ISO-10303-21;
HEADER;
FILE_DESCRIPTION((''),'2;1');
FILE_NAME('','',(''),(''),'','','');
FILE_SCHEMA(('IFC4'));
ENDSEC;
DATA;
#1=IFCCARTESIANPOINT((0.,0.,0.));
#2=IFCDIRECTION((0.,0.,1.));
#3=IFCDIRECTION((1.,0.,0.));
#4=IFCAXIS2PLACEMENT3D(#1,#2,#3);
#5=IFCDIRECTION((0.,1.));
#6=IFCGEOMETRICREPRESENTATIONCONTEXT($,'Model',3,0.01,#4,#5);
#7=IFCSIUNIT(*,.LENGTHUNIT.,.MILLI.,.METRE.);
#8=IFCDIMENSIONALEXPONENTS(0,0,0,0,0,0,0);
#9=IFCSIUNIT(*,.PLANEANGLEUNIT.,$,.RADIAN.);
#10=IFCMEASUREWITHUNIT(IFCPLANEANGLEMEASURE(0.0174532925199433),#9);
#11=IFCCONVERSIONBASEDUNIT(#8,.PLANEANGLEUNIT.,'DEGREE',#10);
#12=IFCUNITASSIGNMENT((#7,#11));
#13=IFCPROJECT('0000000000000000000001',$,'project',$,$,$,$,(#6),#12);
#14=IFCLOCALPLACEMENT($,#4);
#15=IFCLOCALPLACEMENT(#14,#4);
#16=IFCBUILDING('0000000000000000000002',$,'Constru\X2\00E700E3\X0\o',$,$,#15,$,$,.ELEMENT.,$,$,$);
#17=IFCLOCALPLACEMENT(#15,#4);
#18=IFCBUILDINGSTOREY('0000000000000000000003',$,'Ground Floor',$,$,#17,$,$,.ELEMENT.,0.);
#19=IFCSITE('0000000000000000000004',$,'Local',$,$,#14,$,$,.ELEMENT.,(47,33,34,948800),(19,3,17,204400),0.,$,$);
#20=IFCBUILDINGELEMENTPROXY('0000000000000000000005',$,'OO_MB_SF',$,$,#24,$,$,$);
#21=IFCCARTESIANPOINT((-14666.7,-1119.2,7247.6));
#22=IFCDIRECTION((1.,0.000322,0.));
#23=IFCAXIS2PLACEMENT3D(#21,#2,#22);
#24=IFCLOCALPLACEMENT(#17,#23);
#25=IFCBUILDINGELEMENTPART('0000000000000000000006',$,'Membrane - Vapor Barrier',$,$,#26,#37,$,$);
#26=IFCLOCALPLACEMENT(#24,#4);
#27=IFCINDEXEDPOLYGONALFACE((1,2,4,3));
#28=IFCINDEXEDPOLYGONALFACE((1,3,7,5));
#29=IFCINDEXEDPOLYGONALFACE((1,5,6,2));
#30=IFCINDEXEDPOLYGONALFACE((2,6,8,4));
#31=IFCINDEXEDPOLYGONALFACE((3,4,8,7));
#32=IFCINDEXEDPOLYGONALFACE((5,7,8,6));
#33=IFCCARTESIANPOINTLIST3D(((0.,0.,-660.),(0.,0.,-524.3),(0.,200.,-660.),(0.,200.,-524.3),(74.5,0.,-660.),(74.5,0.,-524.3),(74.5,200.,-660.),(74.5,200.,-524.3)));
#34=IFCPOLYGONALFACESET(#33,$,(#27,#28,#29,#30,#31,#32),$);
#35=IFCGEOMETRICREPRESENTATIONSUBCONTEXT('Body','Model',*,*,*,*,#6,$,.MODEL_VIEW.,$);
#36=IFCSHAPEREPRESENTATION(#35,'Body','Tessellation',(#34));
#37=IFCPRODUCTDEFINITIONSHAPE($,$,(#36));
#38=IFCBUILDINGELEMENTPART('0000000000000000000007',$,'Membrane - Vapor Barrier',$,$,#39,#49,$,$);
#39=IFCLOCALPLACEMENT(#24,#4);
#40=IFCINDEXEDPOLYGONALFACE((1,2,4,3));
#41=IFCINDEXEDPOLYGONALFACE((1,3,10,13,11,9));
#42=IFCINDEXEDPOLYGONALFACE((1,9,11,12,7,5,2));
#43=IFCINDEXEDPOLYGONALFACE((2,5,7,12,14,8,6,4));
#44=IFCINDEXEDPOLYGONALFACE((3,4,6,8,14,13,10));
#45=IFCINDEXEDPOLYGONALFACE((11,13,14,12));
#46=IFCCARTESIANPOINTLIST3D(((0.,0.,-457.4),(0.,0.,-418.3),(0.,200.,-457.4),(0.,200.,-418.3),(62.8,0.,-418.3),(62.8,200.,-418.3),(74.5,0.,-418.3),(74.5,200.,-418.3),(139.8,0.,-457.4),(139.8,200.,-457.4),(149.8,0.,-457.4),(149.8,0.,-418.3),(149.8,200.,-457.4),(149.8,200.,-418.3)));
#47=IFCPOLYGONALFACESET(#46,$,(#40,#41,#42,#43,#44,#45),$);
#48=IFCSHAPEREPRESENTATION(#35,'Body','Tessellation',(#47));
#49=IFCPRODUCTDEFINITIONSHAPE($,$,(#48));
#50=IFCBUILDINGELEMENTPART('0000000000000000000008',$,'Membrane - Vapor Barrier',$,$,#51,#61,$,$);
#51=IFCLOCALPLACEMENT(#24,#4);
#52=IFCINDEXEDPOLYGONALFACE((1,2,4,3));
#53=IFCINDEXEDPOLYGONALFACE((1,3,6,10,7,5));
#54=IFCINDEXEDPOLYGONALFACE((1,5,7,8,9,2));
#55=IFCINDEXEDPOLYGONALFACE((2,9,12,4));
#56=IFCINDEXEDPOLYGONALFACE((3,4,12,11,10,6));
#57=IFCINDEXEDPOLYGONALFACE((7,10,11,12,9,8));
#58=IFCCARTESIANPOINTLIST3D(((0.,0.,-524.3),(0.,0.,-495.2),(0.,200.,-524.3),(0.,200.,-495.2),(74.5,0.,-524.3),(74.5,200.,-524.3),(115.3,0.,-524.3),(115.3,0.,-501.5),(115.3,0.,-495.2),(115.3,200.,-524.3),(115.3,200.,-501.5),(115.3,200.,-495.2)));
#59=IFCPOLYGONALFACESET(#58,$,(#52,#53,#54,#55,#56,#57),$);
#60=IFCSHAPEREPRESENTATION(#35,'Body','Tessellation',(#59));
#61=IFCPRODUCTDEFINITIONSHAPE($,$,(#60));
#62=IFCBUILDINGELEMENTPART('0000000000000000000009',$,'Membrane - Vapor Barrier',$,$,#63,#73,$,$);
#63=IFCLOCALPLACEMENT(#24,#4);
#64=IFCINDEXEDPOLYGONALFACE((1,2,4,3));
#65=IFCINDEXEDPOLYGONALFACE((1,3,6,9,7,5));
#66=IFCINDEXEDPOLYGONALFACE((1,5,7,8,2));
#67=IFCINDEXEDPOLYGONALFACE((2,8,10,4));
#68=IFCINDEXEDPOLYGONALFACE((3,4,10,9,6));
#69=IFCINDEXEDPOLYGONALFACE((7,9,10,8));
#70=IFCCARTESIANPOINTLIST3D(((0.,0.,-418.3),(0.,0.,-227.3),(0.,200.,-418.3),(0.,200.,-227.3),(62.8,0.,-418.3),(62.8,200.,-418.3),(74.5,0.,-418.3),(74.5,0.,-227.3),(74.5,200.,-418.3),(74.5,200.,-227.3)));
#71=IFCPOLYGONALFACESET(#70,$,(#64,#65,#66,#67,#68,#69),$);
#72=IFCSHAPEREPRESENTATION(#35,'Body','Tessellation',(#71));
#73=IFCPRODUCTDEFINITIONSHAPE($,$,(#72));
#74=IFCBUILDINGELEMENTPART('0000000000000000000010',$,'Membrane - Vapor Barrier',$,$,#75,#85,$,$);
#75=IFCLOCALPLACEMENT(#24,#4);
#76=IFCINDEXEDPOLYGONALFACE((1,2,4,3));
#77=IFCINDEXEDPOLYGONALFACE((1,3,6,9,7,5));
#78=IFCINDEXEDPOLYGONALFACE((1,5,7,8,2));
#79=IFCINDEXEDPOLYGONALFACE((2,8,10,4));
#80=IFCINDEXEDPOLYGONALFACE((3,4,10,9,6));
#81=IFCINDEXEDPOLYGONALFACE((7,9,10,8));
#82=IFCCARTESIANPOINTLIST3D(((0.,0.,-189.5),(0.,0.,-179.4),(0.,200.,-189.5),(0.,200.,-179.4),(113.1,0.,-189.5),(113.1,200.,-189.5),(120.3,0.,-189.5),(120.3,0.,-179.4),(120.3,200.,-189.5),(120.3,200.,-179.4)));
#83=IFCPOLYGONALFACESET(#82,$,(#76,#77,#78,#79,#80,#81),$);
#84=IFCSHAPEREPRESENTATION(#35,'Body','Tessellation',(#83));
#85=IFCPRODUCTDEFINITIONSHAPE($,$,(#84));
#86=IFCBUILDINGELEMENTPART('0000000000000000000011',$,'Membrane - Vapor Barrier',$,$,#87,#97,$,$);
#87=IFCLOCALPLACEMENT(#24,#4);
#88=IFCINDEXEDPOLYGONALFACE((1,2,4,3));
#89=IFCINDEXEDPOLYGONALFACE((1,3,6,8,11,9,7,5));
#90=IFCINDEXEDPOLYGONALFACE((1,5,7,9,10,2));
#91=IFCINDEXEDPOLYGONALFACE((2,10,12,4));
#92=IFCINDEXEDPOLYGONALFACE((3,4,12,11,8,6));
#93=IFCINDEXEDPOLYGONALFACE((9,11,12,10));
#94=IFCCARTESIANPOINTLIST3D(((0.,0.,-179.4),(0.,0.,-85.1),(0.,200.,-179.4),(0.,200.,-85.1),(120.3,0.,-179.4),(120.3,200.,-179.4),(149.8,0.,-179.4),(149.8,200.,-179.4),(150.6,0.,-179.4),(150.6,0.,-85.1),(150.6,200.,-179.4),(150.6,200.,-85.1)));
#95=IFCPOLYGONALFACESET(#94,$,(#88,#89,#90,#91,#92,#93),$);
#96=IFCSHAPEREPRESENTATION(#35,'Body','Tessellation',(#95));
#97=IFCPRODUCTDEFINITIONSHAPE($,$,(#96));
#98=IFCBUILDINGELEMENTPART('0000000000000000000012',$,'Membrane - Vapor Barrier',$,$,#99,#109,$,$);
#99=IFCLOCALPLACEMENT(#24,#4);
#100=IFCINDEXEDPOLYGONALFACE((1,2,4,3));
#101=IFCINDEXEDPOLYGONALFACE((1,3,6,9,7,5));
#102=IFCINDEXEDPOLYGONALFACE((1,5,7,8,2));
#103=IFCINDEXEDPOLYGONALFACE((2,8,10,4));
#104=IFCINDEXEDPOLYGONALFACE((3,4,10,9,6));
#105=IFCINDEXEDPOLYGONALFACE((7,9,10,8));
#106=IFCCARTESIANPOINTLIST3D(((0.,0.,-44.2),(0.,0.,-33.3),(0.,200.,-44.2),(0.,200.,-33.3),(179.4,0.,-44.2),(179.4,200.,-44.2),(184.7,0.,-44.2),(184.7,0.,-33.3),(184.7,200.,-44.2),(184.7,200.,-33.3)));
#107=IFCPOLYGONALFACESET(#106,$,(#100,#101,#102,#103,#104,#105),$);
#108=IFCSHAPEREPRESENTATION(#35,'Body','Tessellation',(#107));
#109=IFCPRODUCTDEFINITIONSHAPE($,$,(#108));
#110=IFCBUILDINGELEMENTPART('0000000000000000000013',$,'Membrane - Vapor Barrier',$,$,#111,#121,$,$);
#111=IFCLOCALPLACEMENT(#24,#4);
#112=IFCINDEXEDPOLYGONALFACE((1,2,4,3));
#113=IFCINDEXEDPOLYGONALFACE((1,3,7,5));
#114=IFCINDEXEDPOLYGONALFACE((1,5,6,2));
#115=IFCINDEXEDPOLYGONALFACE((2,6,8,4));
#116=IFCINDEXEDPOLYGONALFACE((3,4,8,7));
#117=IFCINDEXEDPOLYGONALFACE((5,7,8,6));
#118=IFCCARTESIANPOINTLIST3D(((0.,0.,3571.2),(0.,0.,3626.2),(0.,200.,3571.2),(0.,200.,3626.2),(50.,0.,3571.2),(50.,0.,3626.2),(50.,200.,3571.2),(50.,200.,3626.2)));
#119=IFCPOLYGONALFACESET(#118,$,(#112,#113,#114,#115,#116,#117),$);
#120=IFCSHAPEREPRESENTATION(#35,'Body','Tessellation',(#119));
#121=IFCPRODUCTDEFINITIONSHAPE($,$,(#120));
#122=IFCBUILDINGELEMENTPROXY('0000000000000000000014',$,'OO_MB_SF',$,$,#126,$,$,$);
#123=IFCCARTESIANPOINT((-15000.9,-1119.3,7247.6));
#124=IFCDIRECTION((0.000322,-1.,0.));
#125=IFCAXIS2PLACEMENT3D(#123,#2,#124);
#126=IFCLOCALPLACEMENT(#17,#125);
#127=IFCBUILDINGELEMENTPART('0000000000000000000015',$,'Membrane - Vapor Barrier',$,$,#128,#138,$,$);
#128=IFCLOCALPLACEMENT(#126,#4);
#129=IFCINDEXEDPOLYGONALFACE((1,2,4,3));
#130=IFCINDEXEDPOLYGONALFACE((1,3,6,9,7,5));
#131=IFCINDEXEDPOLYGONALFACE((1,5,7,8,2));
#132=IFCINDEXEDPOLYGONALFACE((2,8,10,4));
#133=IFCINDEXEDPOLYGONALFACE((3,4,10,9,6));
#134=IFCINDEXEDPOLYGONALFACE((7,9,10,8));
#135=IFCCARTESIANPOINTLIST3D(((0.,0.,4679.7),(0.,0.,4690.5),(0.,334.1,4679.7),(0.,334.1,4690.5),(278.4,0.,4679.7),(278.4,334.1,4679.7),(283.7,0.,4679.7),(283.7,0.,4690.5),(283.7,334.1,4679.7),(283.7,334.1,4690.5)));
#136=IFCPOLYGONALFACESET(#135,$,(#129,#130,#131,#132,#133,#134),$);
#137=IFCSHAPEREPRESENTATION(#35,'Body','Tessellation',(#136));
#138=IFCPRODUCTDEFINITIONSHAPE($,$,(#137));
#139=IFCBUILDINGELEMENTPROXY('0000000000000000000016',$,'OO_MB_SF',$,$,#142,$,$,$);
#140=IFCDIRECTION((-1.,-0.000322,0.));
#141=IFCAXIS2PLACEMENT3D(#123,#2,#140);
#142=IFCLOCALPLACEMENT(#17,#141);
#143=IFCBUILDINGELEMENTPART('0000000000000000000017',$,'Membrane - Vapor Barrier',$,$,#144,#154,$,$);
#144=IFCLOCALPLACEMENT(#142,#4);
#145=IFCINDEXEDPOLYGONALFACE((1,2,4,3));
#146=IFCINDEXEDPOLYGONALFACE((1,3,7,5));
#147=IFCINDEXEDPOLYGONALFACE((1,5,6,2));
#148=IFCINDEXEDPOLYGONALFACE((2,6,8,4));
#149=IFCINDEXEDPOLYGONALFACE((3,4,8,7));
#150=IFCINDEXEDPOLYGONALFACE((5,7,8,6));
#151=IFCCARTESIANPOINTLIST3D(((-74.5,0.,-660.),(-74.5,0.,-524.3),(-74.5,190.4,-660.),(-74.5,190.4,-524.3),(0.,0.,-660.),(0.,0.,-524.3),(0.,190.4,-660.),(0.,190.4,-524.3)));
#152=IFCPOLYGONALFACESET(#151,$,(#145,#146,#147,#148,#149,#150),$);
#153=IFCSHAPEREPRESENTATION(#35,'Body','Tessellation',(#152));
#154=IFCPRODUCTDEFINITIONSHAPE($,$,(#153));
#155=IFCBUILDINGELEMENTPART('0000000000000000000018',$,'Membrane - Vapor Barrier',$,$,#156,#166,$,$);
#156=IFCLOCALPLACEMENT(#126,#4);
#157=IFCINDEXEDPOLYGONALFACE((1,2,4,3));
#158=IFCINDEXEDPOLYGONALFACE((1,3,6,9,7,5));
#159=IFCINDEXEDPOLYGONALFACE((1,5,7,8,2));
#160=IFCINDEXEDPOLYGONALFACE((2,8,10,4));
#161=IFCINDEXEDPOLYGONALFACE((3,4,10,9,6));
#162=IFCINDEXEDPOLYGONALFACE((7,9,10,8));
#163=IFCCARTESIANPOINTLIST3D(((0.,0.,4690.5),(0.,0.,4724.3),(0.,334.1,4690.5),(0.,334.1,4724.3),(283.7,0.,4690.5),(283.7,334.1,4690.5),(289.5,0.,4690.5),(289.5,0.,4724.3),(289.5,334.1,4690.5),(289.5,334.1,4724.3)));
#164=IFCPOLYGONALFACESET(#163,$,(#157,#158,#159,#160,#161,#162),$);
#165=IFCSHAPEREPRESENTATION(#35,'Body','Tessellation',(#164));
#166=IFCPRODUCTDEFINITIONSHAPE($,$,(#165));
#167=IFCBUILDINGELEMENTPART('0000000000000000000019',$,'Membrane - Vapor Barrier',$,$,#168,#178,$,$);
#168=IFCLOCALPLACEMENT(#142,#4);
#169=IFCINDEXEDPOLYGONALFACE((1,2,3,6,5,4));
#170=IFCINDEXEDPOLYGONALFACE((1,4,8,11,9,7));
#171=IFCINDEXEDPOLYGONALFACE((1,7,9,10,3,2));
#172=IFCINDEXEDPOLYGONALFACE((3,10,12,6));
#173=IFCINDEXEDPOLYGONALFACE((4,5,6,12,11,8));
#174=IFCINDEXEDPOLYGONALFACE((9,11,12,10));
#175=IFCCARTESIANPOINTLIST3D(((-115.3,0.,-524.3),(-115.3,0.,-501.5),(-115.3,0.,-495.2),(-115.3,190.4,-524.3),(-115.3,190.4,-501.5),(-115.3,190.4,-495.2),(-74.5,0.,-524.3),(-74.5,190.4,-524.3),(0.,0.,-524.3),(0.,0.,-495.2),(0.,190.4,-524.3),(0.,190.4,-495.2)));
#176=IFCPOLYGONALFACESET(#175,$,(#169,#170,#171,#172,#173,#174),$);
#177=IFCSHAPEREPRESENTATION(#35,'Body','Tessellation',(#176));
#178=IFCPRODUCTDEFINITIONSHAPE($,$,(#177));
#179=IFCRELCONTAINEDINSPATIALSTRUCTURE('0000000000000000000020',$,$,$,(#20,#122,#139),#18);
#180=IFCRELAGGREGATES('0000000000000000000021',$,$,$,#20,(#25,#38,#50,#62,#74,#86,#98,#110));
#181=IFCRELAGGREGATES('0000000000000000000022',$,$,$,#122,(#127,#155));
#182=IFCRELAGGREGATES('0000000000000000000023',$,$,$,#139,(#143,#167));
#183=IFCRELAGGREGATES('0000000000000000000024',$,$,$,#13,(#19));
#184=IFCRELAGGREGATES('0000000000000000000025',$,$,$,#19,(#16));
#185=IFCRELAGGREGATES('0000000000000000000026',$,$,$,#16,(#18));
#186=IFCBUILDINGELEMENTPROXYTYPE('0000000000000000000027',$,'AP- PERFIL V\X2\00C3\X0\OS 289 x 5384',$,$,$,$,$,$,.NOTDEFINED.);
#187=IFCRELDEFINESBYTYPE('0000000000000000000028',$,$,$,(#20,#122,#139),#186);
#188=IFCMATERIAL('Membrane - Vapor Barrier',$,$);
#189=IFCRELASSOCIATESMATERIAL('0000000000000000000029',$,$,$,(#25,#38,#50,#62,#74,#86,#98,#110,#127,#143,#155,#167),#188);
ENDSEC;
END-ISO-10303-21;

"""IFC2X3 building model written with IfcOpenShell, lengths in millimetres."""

from ifc_helpers import new_model, entity, si_unit, converted_unit, direction, frame, origin_with_axes, place, context, subcontext, project, spatial, polyline, outline, extrude, material, type_object, element, aggregate, save


model = new_model("IFC2X3")

# Units and contexts
model_context = context("Model", 3, precision=0.01, world=origin_with_axes(), true_north=direction((0.0, 1.0)))
body_context = subcontext(model_context, "Body", "Model", "MODEL_VIEW")
ifc_project = project(units=[si_unit("LENGTHUNIT", "METRE", prefix="MILLI"), converted_unit("PLANEANGLEUNIT", "DEGREE", entity("IfcPlaneAngleMeasure", 0.0174532925199433), si_unit("PLANEANGLEUNIT", "RADIAN"), dimensions=[0, 0, 0, 0, 0, 0, 0])], contexts=[model_context])

# Site, building, storey
site_placement = place(None, origin_with_axes())
site = spatial("IfcSite", under=ifc_project, at=site_placement, Name="Local", CompositionType="ELEMENT", RefLatitude=(47, 33, 34, 948800), RefLongitude=(19, 3, 17, 204400), RefElevation=0.0)
building_placement = place(site_placement, origin_with_axes())
building = spatial("IfcBuilding", under=site, at=building_placement, Name="Construção", CompositionType="ELEMENT")
storey_placement = place(building_placement, origin_with_axes())
storey = spatial("IfcBuildingStorey", under=building, at=storey_placement, Name="Ground Floor", CompositionType="ELEMENT", Elevation=0.0)

# Building element proxies, building element parts
building_element_proxy_type = type_object("IfcBuildingElementProxyType", Name="AP- PERFIL VÃOS 289 x 5384", PredefinedType="NOTDEFINED")
proxy_1_placement = place(storey_placement, frame((-14666.7, -1119.2, 7247.6), z_axis=(0.0, 0.0, 1.0), x_axis=(1.0, 0.000322, 0.0)))
proxy_1 = element("IfcBuildingElementProxy", 1, at=proxy_1_placement, inside=storey, type_object=building_element_proxy_type, Name="OO_MB_SF")
ifc_material = material(Name="Membrane - Vapor Barrier")
building_element_part_1_placement = place(proxy_1_placement, origin_with_axes())
building_element_part_1 = element("IfcBuildingElementPart", 2, at=building_element_part_1_placement, material=ifc_material, Name="Membrane - Vapor Barrier", context=body_context, shape_type="SweptSolid", body=[
    extrude(outline(polyline([(0.0, -660.0), (74.5, -660.0), (74.5, -524.3), (0.0, -524.3), (0.0, -660.0)])), frame((0.0, 200.0, 0.0), z_axis=(0.0, -1.0, 0.0), x_axis=(1.0, 0.0, 0.0)), (0.0, 0.0, 1.0), 200.0),
])
building_element_part_2_placement = place(proxy_1_placement, origin_with_axes())
building_element_part_2 = element("IfcBuildingElementPart", 3, at=building_element_part_2_placement, material=ifc_material, Name="Membrane - Vapor Barrier", context=body_context, shape_type="SweptSolid", body=[
    extrude(outline(polyline([(62.8, -418.3), (0.0, -418.3), (0.0, -457.4), (139.8, -457.4), (149.8, -457.4), (149.8, -418.3), (74.5, -418.3), (62.8, -418.3)])), frame((0.0, 200.0, 0.0), z_axis=(0.0, -1.0, 0.0), x_axis=(1.0, 0.0, 0.0)), (0.0, 0.0, 1.0), 200.0),
])
building_element_part_3_placement = place(proxy_1_placement, origin_with_axes())
building_element_part_3 = element("IfcBuildingElementPart", 4, at=building_element_part_3_placement, material=ifc_material, Name="Membrane - Vapor Barrier", context=body_context, shape_type="SweptSolid", body=[
    extrude(outline(polyline([(0.0, -524.3), (74.5, -524.3), (115.3, -524.3), (115.3, -501.5), (115.3, -495.2), (0.0, -495.2), (0.0, -524.3)])), frame((0.0, 200.0, 0.0), z_axis=(0.0, -1.0, 0.0), x_axis=(1.0, 0.0, 0.0)), (0.0, 0.0, 1.0), 200.0),
])
building_element_part_4_placement = place(proxy_1_placement, origin_with_axes())
building_element_part_4 = element("IfcBuildingElementPart", 5, at=building_element_part_4_placement, material=ifc_material, Name="Membrane - Vapor Barrier", context=body_context, shape_type="SweptSolid", body=[
    extrude(outline(polyline([(0.0, -227.3), (0.0, -418.3), (62.8, -418.3), (74.5, -418.3), (74.5, -227.3), (0.0, -227.3)])), frame((0.0, 200.0, 0.0), z_axis=(0.0, -1.0, 0.0), x_axis=(1.0, 0.0, 0.0)), (0.0, 0.0, 1.0), 200.0),
])
building_element_part_5_placement = place(proxy_1_placement, origin_with_axes())
building_element_part_5 = element("IfcBuildingElementPart", 6, at=building_element_part_5_placement, material=ifc_material, Name="Membrane - Vapor Barrier", context=body_context, shape_type="SweptSolid", body=[
    extrude(outline(polyline([(120.3, -179.4), (0.0, -179.4), (0.0, -189.5), (113.1, -189.5), (120.3, -189.5), (120.3, -179.4)])), frame((0.0, 200.0, 0.0), z_axis=(0.0, -1.0, 0.0), x_axis=(1.0, 0.0, 0.0)), (0.0, 0.0, 1.0), 200.0),
])
building_element_part_6_placement = place(proxy_1_placement, origin_with_axes())
building_element_part_6 = element("IfcBuildingElementPart", 7, at=building_element_part_6_placement, material=ifc_material, Name="Membrane - Vapor Barrier", context=body_context, shape_type="SweptSolid", body=[
    extrude(outline(polyline([(0.0, -85.1), (0.0, -179.4), (120.3, -179.4), (149.8, -179.4), (150.6, -179.4), (150.6, -85.1), (0.0, -85.1)])), frame((0.0, 200.0, 0.0), z_axis=(0.0, -1.0, 0.0), x_axis=(1.0, 0.0, 0.0)), (0.0, 0.0, 1.0), 200.0),
])
building_element_part_7_placement = place(proxy_1_placement, origin_with_axes())
building_element_part_7 = element("IfcBuildingElementPart", 8, at=building_element_part_7_placement, material=ifc_material, Name="Membrane - Vapor Barrier", context=body_context, shape_type="SweptSolid", body=[
    extrude(outline(polyline([(184.7, -33.3), (0.0, -33.3), (0.0, -44.2), (179.4, -44.2), (184.7, -44.2), (184.7, -33.3)])), frame((0.0, 200.0, 0.0), z_axis=(0.0, -1.0, 0.0), x_axis=(1.0, 0.0, 0.0)), (0.0, 0.0, 1.0), 200.0),
])
building_element_part_8_placement = place(proxy_1_placement, origin_with_axes())
building_element_part_8 = element("IfcBuildingElementPart", 9, at=building_element_part_8_placement, material=ifc_material, Name="Membrane - Vapor Barrier", context=body_context, shape_type="SweptSolid", body=[
    extrude(outline(polyline([(0.0, 3571.2), (50.0, 3571.2), (50.0, 3626.2), (0.0, 3626.2), (0.0, 3571.2)])), frame((0.0, 200.0, 0.0), z_axis=(0.0, -1.0, 0.0), x_axis=(1.0, 0.0, 0.0)), (0.0, 0.0, 1.0), 200.0),
])
aggregate(proxy_1, [building_element_part_1, building_element_part_2, building_element_part_3, building_element_part_4, building_element_part_5, building_element_part_6, building_element_part_7, building_element_part_8])
proxy_2_placement = place(storey_placement, frame((-15000.9, -1119.3, 7247.6), z_axis=(0.0, 0.0, 1.0), x_axis=(0.000322, -1.0, 0.0)))
proxy_2 = element("IfcBuildingElementProxy", 10, at=proxy_2_placement, inside=storey, type_object=building_element_proxy_type, Name="OO_MB_SF")
building_element_part_9_placement = place(proxy_2_placement, origin_with_axes())
building_element_part_9 = element("IfcBuildingElementPart", 11, at=building_element_part_9_placement, material=ifc_material, Name="Membrane - Vapor Barrier", context=body_context, shape_type="SweptSolid", body=[
    extrude(outline(polyline([(0.0, 4679.7), (278.4, 4679.7), (283.7, 4679.7), (283.7, 4690.5), (0.0, 4690.5), (0.0, 4679.7)])), frame((0.0, 334.1, 0.0), z_axis=(0.0, -1.0, 0.0), x_axis=(1.0, 0.0, 0.0)), (0.0, 0.0, 1.0), 334.1),
])
proxy_3_placement = place(storey_placement, frame((-15000.9, -1119.3, 7247.6), z_axis=(0.0, 0.0, 1.0), x_axis=(-1.0, -0.000322, 0.0)))
proxy_3 = element("IfcBuildingElementProxy", 12, at=proxy_3_placement, inside=storey, type_object=building_element_proxy_type, Name="OO_MB_SF")
building_element_part_10_placement = place(proxy_3_placement, origin_with_axes())
building_element_part_10 = element("IfcBuildingElementPart", 13, at=building_element_part_10_placement, material=ifc_material, Name="Membrane - Vapor Barrier", context=body_context, shape_type="SweptSolid", body=[
    extrude(outline(polyline([(0.0, -660.0), (74.5, -660.0), (74.5, -524.3), (0.0, -524.3), (0.0, -660.0)])), frame((0.0, 190.4, 0.0), z_axis=(0.0, 1.0, 0.0), x_axis=(-1.0, 0.0, 0.0)), (0.0, 0.0, -1.0), 190.4),
])

# Building element parts
building_element_part_11_placement = place(proxy_2_placement, origin_with_axes())
building_element_part_11 = element("IfcBuildingElementPart", 14, at=building_element_part_11_placement, material=ifc_material, Name="Membrane - Vapor Barrier", context=body_context, shape_type="SweptSolid", body=[
    extrude(outline(polyline([(0.0, 4690.5), (283.7, 4690.5), (289.5, 4690.5), (289.5, 4724.3), (0.0, 4724.3), (0.0, 4690.5)])), frame((0.0, 334.1, 0.0), z_axis=(0.0, -1.0, 0.0), x_axis=(1.0, 0.0, 0.0)), (0.0, 0.0, 1.0), 334.1),
])
aggregate(proxy_2, [building_element_part_9, building_element_part_11])
building_element_part_12_placement = place(proxy_3_placement, origin_with_axes())
building_element_part_12 = element("IfcBuildingElementPart", 15, at=building_element_part_12_placement, material=ifc_material, Name="Membrane - Vapor Barrier", context=body_context, shape_type="SweptSolid", body=[
    extrude(outline(polyline([(0.0, -524.3), (74.5, -524.3), (115.3, -524.3), (115.3, -501.5), (115.3, -495.2), (0.0, -495.2), (0.0, -524.3)])), frame((0.0, 190.4, 0.0), z_axis=(0.0, 1.0, 0.0), x_axis=(-1.0, 0.0, 0.0)), (0.0, 0.0, -1.0), 190.4),
])
aggregate(proxy_3, [building_element_part_10, building_element_part_12])

save(model, "model.ifc")
